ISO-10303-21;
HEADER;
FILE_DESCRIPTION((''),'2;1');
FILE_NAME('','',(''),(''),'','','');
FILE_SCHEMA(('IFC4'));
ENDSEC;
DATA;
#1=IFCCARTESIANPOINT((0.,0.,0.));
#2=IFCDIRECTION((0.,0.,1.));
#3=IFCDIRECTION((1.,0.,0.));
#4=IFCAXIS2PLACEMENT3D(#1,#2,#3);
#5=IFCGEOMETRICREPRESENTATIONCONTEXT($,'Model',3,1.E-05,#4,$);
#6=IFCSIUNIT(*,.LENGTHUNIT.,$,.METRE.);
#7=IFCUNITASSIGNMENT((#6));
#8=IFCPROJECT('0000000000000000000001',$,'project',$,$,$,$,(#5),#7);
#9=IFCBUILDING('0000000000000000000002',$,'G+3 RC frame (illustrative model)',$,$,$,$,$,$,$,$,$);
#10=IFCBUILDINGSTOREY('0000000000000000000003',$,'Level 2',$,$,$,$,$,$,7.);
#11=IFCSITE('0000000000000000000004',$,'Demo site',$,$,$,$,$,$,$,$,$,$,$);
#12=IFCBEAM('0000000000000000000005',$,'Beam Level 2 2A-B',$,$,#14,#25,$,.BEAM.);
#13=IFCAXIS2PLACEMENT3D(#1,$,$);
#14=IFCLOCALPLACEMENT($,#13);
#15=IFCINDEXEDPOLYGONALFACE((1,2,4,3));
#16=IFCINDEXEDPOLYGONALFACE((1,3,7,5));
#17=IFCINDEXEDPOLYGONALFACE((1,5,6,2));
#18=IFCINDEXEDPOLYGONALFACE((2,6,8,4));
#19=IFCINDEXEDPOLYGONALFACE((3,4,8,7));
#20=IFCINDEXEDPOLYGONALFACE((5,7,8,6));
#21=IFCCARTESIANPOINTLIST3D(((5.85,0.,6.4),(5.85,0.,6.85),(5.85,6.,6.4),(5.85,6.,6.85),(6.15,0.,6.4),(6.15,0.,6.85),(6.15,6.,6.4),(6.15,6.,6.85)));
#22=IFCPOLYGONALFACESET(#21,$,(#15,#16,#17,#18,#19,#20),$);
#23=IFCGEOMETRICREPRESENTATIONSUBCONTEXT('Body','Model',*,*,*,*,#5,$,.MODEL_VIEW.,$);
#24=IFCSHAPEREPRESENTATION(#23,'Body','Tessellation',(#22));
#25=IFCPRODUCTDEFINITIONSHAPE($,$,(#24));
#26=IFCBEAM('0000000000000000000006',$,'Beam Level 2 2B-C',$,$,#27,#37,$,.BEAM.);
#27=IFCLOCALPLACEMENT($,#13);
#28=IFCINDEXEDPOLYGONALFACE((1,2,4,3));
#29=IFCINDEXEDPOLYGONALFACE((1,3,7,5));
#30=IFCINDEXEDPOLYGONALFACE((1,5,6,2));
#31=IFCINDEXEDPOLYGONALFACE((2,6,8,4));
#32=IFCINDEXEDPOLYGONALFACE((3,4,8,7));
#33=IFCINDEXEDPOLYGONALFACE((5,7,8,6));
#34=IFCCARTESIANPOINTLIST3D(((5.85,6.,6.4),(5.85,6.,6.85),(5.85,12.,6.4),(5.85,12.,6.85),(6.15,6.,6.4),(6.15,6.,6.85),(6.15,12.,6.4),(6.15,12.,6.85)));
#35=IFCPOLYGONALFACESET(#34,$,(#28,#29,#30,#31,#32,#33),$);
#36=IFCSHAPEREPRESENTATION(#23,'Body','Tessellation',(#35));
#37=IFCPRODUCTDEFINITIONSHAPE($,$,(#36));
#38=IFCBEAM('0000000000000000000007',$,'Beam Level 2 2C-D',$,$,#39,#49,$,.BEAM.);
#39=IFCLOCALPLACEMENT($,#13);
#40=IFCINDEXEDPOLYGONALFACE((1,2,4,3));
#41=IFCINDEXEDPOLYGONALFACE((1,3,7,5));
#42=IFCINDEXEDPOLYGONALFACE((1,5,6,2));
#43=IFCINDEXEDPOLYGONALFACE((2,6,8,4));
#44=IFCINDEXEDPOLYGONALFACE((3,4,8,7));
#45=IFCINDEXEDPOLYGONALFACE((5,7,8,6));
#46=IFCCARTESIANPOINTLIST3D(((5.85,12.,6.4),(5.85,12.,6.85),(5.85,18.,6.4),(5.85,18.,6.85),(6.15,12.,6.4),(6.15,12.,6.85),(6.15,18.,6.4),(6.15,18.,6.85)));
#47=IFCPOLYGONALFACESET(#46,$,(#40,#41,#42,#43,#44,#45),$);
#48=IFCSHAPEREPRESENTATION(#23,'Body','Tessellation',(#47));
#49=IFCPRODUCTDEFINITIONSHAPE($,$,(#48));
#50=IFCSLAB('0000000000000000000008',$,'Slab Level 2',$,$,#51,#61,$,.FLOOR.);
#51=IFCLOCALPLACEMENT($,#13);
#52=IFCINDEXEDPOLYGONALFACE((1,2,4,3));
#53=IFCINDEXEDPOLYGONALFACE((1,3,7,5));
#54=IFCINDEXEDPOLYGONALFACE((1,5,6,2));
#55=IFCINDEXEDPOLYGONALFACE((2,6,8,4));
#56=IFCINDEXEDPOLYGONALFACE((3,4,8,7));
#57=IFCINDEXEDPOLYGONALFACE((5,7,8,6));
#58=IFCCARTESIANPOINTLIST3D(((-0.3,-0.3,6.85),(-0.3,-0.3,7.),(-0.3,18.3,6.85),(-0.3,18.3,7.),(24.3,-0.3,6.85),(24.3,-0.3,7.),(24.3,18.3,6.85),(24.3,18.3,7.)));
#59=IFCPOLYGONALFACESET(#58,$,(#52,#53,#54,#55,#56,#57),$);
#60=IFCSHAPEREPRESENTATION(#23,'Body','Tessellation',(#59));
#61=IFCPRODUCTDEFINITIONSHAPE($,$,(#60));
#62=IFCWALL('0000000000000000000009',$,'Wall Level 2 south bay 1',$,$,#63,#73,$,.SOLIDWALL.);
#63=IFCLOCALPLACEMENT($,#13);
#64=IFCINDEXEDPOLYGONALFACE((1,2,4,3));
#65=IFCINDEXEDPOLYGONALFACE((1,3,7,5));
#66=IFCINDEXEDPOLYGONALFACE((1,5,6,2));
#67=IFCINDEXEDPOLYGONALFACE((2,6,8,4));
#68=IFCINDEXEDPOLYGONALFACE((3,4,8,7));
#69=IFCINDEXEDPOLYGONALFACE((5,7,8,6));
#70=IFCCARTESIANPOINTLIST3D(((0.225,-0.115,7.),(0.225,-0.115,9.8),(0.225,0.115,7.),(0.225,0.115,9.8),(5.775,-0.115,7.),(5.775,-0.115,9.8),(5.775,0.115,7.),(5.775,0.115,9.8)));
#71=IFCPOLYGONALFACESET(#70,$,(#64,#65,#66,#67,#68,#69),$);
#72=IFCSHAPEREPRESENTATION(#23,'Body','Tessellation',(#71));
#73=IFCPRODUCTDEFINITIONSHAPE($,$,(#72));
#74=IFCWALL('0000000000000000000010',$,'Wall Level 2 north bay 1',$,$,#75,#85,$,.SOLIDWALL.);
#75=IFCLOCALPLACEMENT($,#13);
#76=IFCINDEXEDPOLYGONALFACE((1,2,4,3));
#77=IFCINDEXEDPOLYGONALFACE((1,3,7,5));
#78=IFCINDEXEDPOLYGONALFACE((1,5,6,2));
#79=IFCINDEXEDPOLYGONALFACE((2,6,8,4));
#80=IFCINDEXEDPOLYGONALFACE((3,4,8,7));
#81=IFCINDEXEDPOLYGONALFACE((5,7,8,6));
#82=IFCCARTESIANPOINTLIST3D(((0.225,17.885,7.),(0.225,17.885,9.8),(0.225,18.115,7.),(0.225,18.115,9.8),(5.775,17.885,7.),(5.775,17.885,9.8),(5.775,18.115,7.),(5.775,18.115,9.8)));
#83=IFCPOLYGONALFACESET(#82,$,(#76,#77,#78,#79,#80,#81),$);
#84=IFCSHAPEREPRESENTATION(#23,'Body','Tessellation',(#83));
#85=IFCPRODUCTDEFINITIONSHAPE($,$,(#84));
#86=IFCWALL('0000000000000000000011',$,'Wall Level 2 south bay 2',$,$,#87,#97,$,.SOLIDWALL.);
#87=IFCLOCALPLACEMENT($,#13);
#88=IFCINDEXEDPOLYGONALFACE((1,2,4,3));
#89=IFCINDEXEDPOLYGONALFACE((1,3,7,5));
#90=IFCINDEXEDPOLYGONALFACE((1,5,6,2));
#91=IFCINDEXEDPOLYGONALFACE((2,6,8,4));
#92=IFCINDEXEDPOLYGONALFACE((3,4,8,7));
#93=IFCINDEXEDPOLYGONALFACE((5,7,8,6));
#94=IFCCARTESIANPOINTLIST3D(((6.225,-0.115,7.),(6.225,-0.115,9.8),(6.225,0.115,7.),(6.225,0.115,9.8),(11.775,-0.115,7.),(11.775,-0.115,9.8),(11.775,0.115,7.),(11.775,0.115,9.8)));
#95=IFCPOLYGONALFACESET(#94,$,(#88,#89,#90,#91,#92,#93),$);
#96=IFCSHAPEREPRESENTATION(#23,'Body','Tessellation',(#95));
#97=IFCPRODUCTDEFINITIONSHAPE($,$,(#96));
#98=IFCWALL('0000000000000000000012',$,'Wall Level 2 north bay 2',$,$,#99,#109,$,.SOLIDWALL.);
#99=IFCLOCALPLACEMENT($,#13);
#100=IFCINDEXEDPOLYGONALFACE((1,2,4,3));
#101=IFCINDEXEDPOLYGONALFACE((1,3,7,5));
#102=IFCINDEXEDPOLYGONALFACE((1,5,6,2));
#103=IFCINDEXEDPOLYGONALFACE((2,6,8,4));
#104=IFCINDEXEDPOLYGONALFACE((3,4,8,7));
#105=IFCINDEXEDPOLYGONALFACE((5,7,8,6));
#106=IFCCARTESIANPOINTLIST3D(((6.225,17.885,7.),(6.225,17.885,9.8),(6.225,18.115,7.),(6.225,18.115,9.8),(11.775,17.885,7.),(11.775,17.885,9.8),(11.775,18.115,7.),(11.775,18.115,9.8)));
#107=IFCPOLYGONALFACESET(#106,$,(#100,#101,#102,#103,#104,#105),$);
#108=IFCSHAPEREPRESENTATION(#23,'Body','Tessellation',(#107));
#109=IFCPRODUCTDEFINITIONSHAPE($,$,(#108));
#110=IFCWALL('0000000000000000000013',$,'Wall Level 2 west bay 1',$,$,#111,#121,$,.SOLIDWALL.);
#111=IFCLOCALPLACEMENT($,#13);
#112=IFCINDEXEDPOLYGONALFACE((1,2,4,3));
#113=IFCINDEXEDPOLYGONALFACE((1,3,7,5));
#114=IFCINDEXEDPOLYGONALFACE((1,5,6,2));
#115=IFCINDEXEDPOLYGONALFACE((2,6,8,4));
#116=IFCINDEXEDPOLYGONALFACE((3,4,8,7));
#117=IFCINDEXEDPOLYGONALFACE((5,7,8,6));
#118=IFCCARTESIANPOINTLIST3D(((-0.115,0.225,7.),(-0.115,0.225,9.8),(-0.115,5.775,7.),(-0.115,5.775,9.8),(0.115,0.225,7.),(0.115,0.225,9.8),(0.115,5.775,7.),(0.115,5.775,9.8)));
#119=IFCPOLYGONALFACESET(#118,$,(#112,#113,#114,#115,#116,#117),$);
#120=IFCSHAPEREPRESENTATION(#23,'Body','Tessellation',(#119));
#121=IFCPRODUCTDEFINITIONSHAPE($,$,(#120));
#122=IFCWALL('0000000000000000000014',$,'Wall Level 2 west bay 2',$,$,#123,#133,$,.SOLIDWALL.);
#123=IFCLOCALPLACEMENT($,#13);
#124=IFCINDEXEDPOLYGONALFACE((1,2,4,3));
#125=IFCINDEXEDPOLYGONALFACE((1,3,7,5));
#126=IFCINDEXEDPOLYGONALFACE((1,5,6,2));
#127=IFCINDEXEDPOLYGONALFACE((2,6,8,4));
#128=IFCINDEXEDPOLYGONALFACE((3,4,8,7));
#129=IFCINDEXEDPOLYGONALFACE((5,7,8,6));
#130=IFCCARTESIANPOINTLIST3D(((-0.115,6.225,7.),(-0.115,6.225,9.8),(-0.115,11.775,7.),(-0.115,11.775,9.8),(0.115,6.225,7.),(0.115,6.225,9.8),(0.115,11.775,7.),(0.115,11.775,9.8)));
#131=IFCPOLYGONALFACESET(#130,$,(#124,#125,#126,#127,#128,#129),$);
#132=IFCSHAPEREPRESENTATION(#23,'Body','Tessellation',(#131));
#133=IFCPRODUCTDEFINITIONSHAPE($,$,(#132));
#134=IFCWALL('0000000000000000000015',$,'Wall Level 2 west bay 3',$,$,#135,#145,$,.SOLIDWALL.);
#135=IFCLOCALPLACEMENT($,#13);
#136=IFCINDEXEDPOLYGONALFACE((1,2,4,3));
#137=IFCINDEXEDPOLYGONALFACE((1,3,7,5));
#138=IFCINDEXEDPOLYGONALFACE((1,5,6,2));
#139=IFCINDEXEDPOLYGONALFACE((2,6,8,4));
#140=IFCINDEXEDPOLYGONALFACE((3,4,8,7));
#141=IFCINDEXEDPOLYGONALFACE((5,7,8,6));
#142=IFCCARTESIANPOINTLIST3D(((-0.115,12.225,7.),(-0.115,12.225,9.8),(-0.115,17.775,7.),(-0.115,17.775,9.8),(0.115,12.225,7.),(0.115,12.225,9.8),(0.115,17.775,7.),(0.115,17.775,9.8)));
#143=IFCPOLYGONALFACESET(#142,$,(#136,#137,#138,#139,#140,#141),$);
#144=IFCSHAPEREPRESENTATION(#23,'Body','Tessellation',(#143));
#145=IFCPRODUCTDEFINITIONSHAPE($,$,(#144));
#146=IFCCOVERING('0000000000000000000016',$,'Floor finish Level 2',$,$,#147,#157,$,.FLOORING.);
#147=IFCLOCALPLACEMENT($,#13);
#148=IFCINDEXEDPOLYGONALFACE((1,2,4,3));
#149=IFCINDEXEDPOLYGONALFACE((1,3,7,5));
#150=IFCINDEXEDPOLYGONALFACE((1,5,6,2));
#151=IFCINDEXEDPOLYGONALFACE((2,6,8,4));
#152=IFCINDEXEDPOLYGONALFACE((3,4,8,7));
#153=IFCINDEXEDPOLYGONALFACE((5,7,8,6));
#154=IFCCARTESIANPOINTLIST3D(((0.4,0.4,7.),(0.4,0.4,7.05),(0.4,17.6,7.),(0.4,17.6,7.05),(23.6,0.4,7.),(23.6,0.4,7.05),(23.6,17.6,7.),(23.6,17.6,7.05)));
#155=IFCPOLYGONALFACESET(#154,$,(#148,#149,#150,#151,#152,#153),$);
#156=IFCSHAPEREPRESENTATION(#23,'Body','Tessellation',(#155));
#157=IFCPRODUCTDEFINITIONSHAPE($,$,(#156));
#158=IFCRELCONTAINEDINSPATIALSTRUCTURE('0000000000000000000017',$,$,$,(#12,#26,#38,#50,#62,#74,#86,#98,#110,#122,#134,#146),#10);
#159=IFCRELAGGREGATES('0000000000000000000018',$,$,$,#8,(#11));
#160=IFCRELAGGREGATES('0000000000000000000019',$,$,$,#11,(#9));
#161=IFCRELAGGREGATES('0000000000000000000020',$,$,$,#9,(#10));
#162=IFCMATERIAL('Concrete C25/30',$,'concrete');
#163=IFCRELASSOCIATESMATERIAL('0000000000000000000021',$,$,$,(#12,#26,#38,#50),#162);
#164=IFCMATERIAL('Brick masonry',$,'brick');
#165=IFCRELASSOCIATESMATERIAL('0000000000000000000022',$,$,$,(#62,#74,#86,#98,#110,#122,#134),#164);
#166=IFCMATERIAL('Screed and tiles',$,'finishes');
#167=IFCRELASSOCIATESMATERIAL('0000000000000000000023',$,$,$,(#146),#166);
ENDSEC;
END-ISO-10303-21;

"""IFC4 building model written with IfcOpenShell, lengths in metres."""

from ifc_helpers import new_model, si_unit, frame, frame_2d, origin, origin_with_axes, place, context, subcontext, project, spatial, rectangle, extrude, material, element, save


model = new_model("IFC4")

# Units and contexts
model_context = context("Model", 3, precision=1e-05, world=origin_with_axes())
body_context = subcontext(model_context, "Body", "Model", "MODEL_VIEW")
ifc_project = project(units=[si_unit("LENGTHUNIT", "METRE")], contexts=[model_context])

# Site, building, storey
site = spatial("IfcSite", under=ifc_project, Name="Demo site")
building = spatial("IfcBuilding", under=site, Name="G+3 RC frame (illustrative model)")
storey = spatial("IfcBuildingStorey", under=building, Name="Level 2", Elevation=7.0)

# Shared definitions
ifc_material_1 = material(Name="Concrete C25/30", Category="concrete")

# Beams
for number, where, z_axis, x_axis, name in (
    (1, (5.85, 0.0, 6.4), (0.0, 0.0, 1.0), (1.0, 0.0, 0.0), "Beam Level 2 2A-B"),
    (2, (5.85, 6.0, 6.4), (0.0, 0.0, 1.0), (1.0, 0.0, 0.0), "Beam Level 2 2B-C"),
    (3, (5.85, 12.0, 6.4), (0.0, 0.0, 1.0), (1.0, 0.0, 0.0), "Beam Level 2 2C-D"),
):
    element("IfcBeam", number, at=place(None, frame(where, z_axis=z_axis, x_axis=x_axis)), inside=storey, material=ifc_material_1, Name=name, PredefinedType="BEAM", context=body_context, shape_type="SweptSolid", body=[
        extrude(rectangle(XDim=0.3, YDim=6.0, at=frame_2d((0.15, 3.0))), origin(), (0.0, 0.0, 1.0), 0.45),
    ])

# Slab
slab_placement = place(None, frame((-0.3, -0.3, 6.85), z_axis=(0.0, 0.0, 1.0), x_axis=(1.0, 0.0, 0.0)))
element("IfcSlab", 4, at=slab_placement, inside=storey, material=ifc_material_1, Name="Slab Level 2", PredefinedType="FLOOR", context=body_context, shape_type="SweptSolid", body=[
    extrude(rectangle(XDim=24.6, YDim=18.6, at=frame_2d((12.3, 9.3))), origin(), (0.0, 0.0, 1.0), 0.15),
])

# Walls
ifc_material_2 = material(Name="Brick masonry", Category="brick")
for number, where, z_axis, x_axis, name in (
    (5, (0.225, -0.115, 7.0), (0.0, 0.0, 1.0), (1.0, 0.0, 0.0), "Wall Level 2 south bay 1"),
    (6, (0.225, 17.885, 7.0), (0.0, 0.0, 1.0), (1.0, 0.0, 0.0), "Wall Level 2 north bay 1"),
    (7, (6.225, -0.115, 7.0), (0.0, 0.0, 1.0), (1.0, 0.0, 0.0), "Wall Level 2 south bay 2"),
    (8, (6.225, 17.885, 7.0), (0.0, 0.0, 1.0), (1.0, 0.0, 0.0), "Wall Level 2 north bay 2"),
):
    element("IfcWall", number, at=place(None, frame(where, z_axis=z_axis, x_axis=x_axis)), inside=storey, material=ifc_material_2, Name=name, PredefinedType="SOLIDWALL", context=body_context, shape_type="SweptSolid", body=[
        extrude(rectangle(XDim=5.55, YDim=0.23, at=frame_2d((2.775, 0.115))), origin(), (0.0, 0.0, 1.0), 2.8),
    ])
for number, where, z_axis, x_axis, name in (
    (9, (-0.115, 0.225, 7.0), (0.0, 0.0, 1.0), (1.0, 0.0, 0.0), "Wall Level 2 west bay 1"),
    (10, (-0.115, 6.225, 7.0), (0.0, 0.0, 1.0), (1.0, 0.0, 0.0), "Wall Level 2 west bay 2"),
    (11, (-0.115, 12.225, 7.0), (0.0, 0.0, 1.0), (1.0, 0.0, 0.0), "Wall Level 2 west bay 3"),
):
    element("IfcWall", number, at=place(None, frame(where, z_axis=z_axis, x_axis=x_axis)), inside=storey, material=ifc_material_2, Name=name, PredefinedType="SOLIDWALL", context=body_context, shape_type="SweptSolid", body=[
        extrude(rectangle(XDim=0.23, YDim=5.55, at=frame_2d((0.115, 2.775))), origin(), (0.0, 0.0, 1.0), 2.8),
    ])

# Covering
ifc_material_3 = material(Name="Screed and tiles", Category="finishes")
covering_placement = place(None, frame((0.4, 0.4, 7.0), z_axis=(0.0, 0.0, 1.0), x_axis=(1.0, 0.0, 0.0)))
element("IfcCovering", 12, at=covering_placement, inside=storey, material=ifc_material_3, Name="Floor finish Level 2", PredefinedType="FLOORING", context=body_context, shape_type="SweptSolid", body=[
    extrude(rectangle(XDim=23.2, YDim=17.2, at=frame_2d((11.6, 8.6))), origin(), (0.0, 0.0, 1.0), 0.05),
])

save(model, "model.ifc")
